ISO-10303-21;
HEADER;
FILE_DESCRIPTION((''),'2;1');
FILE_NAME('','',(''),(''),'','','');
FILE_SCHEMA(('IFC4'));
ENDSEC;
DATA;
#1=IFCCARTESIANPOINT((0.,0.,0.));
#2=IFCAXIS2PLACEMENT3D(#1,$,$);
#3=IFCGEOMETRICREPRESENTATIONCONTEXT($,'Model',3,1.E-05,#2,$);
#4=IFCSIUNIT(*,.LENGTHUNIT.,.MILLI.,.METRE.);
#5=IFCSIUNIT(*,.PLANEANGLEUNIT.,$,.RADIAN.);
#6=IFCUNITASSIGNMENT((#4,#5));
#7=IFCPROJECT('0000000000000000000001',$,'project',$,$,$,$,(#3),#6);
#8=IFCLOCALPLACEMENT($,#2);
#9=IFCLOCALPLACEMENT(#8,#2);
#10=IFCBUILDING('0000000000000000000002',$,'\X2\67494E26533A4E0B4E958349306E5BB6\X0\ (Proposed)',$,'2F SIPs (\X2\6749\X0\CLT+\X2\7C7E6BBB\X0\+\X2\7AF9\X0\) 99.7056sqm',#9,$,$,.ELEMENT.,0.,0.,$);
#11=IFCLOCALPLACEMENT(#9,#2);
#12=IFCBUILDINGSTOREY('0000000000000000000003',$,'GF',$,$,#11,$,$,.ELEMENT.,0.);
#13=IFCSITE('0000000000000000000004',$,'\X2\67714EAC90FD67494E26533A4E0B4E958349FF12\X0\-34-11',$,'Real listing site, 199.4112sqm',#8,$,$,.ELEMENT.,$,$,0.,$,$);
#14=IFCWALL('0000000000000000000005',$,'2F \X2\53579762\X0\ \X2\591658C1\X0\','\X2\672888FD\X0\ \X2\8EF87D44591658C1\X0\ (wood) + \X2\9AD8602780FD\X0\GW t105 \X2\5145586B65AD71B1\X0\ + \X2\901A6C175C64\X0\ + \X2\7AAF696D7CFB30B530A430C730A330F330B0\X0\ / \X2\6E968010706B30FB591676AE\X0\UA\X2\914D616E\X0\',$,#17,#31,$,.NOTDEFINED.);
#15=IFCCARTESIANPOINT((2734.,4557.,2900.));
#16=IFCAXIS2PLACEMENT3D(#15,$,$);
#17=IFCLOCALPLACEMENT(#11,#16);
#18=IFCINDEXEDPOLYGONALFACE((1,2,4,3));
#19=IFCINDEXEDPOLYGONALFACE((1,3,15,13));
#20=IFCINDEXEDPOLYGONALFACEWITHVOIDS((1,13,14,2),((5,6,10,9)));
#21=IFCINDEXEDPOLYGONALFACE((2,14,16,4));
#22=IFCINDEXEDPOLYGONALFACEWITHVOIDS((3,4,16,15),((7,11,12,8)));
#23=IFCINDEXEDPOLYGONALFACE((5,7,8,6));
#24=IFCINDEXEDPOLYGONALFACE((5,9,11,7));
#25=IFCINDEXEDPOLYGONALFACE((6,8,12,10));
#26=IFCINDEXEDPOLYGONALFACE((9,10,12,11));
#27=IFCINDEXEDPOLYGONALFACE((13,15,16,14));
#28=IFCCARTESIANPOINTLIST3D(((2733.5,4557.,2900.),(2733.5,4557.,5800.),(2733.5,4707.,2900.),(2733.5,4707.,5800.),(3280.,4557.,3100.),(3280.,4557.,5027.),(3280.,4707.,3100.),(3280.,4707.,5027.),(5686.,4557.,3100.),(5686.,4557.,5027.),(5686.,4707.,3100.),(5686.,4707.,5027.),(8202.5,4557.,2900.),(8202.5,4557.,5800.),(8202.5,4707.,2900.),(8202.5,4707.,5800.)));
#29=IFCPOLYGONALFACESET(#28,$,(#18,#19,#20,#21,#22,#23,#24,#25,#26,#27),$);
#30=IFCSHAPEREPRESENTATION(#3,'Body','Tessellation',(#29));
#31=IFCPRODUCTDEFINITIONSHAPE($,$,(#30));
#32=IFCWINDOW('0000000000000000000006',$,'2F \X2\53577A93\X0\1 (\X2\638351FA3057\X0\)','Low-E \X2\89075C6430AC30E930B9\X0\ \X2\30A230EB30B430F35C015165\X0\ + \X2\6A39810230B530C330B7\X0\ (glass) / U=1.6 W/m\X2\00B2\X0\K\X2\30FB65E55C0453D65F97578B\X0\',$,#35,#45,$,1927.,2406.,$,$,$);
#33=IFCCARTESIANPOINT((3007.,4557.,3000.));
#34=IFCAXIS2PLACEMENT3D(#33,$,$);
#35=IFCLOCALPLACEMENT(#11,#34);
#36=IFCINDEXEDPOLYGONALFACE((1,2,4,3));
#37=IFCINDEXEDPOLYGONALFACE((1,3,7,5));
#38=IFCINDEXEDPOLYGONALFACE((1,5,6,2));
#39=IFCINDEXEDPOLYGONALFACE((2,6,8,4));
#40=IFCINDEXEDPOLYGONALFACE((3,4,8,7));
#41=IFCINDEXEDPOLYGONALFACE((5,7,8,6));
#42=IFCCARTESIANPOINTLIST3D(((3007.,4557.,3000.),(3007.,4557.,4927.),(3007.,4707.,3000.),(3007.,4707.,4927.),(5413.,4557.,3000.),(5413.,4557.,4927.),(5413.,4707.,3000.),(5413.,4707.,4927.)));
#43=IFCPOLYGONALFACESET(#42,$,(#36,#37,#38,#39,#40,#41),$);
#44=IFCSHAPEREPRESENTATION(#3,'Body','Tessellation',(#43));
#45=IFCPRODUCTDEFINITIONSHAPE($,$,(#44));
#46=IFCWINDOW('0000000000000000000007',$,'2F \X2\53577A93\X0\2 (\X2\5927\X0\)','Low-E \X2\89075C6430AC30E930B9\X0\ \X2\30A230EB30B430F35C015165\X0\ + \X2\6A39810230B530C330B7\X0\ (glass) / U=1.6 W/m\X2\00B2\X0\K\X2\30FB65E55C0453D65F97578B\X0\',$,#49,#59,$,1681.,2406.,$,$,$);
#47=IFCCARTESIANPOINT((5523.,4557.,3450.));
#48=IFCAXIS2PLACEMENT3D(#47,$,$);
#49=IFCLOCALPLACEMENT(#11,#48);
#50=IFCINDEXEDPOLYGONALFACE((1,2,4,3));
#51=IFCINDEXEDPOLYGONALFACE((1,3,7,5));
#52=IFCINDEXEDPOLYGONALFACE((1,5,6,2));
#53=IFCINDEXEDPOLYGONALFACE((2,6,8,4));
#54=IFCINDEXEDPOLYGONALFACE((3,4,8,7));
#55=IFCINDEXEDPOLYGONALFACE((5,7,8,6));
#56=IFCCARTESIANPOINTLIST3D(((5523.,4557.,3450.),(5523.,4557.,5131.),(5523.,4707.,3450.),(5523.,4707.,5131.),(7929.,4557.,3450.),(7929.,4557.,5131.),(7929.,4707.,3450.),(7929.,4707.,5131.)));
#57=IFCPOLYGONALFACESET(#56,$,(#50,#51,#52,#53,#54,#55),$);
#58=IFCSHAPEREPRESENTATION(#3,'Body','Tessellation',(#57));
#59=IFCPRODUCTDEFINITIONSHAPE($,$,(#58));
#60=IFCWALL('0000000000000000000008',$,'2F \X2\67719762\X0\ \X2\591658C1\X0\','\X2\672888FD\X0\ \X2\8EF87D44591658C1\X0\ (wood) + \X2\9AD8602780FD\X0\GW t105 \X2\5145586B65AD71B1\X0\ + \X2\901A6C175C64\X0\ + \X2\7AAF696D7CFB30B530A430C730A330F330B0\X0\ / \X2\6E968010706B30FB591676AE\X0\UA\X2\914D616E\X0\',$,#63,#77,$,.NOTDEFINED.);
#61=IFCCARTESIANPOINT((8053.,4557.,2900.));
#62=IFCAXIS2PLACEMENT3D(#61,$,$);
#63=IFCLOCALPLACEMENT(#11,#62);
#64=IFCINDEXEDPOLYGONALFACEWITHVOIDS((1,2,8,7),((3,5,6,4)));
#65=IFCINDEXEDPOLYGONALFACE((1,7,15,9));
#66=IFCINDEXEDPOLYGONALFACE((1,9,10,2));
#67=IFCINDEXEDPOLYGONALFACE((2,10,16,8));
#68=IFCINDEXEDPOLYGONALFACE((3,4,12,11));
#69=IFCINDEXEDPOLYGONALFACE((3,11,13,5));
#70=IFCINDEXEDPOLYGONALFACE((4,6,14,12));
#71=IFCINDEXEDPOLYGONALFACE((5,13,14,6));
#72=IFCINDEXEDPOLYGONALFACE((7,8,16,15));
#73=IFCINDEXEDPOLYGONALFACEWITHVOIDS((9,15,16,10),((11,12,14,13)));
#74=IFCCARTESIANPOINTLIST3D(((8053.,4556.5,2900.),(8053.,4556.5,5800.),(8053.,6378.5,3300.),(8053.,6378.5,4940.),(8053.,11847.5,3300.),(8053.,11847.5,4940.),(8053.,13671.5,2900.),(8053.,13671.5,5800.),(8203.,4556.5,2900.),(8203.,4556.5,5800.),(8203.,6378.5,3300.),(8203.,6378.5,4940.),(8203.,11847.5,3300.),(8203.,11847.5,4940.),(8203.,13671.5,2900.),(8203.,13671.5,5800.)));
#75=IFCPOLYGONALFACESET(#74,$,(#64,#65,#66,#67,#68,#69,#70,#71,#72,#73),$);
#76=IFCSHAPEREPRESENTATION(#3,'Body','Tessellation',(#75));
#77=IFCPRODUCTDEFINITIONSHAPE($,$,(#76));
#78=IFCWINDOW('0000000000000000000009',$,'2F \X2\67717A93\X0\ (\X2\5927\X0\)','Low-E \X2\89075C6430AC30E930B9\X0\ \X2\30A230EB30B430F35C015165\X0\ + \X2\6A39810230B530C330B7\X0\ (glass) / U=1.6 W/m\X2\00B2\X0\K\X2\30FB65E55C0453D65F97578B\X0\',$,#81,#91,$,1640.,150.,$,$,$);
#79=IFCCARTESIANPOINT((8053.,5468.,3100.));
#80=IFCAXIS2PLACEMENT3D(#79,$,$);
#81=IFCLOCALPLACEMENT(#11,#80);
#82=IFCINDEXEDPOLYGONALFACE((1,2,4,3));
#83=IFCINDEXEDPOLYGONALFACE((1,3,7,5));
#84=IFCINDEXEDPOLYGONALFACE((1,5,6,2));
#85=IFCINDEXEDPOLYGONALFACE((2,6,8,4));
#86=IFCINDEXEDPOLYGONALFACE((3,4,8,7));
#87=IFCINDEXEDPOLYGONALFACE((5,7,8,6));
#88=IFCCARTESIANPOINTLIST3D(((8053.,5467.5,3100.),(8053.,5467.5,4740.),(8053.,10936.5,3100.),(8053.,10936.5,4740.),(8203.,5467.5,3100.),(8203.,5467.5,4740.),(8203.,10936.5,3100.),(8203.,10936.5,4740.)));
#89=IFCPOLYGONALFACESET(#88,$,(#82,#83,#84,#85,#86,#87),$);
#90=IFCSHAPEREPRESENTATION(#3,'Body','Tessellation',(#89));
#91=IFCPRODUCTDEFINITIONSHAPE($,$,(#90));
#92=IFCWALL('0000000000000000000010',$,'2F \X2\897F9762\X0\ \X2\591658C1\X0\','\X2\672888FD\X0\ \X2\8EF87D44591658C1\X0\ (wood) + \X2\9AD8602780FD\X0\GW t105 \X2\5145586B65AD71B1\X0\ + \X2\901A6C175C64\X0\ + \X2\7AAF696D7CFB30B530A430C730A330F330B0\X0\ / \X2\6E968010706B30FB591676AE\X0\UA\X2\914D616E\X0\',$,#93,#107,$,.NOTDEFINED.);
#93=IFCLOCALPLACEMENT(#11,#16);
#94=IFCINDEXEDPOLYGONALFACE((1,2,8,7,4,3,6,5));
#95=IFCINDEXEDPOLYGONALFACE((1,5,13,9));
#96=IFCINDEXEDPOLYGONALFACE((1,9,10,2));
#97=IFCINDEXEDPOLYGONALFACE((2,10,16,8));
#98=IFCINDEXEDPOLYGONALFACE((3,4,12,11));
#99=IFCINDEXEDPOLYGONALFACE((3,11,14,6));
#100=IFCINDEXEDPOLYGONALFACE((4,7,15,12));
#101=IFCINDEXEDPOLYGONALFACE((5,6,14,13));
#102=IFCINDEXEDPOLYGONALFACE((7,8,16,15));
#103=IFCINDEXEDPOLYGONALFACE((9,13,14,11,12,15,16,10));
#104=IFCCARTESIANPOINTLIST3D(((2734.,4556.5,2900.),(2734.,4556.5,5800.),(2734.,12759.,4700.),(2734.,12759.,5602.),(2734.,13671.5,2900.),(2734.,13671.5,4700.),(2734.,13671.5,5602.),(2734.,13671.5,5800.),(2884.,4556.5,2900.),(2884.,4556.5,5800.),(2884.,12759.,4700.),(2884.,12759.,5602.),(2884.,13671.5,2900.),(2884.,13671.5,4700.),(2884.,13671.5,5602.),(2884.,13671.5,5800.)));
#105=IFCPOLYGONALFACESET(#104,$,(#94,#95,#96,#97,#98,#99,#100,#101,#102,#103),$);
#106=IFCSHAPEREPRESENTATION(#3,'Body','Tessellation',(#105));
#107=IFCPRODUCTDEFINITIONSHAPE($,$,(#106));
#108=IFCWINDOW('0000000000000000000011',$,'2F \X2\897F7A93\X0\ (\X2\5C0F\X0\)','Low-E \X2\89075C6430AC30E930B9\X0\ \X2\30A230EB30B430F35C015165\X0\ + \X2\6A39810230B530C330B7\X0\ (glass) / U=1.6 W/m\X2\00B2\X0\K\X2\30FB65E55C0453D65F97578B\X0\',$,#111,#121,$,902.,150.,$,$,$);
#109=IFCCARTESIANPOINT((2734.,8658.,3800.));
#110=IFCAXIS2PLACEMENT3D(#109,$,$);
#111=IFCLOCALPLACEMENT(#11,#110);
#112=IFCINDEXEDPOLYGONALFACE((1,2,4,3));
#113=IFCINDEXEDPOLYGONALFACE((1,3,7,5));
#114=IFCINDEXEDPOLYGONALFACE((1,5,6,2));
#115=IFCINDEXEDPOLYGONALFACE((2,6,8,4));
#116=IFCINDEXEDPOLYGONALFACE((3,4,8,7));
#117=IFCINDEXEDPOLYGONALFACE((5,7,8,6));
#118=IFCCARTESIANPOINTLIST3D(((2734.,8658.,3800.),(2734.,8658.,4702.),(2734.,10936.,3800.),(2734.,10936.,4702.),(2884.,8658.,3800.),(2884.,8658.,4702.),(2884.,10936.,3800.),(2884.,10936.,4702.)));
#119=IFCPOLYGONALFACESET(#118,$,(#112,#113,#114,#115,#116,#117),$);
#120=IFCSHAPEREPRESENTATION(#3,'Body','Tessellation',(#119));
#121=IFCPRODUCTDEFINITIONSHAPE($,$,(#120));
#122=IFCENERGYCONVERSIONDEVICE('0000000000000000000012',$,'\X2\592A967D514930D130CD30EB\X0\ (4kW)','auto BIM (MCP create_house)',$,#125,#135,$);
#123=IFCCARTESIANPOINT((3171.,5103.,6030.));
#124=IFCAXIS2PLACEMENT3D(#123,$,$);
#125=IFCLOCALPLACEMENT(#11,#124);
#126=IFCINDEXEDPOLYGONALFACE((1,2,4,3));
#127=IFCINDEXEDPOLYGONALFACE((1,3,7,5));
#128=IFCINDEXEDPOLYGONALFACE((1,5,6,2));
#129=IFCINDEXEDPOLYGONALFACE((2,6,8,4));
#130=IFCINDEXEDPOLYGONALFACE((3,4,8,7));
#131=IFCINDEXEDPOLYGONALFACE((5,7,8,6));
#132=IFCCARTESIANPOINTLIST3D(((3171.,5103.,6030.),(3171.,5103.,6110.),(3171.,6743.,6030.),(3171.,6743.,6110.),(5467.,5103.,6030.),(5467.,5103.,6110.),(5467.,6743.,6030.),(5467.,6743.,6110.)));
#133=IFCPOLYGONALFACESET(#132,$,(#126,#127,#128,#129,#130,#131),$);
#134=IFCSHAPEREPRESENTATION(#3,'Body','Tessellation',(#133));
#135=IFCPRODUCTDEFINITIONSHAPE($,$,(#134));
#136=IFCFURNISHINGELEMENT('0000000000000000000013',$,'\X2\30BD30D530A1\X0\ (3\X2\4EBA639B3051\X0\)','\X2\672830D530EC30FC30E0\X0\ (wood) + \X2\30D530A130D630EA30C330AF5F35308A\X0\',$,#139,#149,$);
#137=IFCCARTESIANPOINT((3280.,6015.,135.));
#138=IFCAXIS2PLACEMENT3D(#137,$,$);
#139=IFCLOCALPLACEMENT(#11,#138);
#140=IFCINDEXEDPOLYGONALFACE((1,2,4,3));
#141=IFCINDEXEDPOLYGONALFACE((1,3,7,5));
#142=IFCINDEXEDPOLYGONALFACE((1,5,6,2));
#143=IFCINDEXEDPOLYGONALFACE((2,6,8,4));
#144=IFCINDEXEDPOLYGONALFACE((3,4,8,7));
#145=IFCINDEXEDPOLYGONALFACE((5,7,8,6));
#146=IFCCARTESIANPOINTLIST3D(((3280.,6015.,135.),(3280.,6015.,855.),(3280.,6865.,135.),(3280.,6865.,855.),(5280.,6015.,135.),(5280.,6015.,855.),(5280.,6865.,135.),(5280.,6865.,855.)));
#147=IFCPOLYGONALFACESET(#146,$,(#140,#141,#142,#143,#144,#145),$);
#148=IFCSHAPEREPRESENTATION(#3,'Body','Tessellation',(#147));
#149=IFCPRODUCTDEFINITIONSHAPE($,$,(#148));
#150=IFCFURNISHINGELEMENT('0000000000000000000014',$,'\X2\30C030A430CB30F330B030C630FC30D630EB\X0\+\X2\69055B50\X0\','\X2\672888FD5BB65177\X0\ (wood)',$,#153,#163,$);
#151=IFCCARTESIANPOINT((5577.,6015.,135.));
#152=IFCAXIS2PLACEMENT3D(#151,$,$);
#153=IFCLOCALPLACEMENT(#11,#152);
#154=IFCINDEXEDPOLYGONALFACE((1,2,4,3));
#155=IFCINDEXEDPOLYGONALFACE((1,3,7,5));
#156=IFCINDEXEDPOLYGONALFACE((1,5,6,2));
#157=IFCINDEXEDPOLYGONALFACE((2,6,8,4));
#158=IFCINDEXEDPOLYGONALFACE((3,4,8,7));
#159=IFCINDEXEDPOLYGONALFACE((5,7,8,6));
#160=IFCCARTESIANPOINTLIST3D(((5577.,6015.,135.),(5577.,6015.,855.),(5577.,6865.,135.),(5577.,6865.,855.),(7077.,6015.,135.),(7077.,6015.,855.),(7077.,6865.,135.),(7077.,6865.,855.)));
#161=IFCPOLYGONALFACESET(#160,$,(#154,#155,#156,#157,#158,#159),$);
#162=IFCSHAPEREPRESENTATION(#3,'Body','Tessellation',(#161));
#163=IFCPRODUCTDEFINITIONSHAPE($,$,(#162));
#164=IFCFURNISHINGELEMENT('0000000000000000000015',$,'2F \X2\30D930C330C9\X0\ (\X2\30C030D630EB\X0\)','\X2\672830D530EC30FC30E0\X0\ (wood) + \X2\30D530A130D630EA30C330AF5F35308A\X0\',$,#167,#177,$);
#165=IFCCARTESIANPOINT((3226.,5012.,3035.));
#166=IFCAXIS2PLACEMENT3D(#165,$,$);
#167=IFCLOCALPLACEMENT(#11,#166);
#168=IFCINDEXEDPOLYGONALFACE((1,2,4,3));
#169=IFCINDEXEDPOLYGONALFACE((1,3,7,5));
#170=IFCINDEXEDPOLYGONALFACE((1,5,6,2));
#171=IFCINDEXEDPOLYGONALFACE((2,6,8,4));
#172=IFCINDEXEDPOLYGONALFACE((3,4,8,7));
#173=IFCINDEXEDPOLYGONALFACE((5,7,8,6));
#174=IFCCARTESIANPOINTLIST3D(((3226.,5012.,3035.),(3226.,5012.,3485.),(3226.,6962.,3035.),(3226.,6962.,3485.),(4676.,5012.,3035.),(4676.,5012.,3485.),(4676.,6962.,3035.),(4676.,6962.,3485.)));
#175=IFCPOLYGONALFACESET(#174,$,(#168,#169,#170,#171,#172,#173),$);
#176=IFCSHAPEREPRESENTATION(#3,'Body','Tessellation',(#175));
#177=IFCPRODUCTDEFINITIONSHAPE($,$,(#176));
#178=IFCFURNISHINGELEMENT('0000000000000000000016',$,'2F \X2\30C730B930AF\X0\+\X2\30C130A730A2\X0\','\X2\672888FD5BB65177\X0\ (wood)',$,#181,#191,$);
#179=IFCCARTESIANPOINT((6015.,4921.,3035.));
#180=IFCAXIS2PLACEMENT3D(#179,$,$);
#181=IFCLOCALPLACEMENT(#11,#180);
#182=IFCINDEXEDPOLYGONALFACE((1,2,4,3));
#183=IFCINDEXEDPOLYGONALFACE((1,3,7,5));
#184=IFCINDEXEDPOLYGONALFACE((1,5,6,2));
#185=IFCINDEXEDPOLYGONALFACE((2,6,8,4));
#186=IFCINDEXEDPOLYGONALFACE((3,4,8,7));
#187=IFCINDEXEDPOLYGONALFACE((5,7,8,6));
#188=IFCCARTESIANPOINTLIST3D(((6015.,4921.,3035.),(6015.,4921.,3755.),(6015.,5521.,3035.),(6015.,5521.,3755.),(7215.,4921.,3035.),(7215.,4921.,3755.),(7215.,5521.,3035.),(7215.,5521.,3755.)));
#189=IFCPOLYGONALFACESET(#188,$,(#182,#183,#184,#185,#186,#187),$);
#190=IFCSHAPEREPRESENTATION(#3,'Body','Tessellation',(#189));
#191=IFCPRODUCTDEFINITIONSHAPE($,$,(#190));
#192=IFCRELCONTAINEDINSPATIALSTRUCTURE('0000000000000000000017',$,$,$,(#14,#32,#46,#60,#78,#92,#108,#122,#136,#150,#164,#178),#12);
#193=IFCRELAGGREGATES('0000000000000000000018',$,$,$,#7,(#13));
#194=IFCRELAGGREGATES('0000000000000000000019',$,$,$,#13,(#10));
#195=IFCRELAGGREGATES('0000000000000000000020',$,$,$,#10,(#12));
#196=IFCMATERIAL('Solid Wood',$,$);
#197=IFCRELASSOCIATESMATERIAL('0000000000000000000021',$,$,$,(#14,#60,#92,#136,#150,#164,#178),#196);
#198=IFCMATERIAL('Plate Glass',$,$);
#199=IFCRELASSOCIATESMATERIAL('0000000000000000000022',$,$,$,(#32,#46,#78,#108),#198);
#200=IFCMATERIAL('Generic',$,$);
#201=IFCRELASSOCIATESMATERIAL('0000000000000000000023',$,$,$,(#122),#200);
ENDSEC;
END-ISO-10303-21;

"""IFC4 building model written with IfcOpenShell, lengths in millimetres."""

from ifc_helpers import new_model, si_unit, frame, frame_2d, origin, place, context, project, spatial, rectangle, extrude, material, element, fill, save


model = new_model("IFC4")

# Units and contexts
model_context = context("Model", 3, precision=1e-05, world=origin())
ifc_project = project(units=[si_unit("LENGTHUNIT", "METRE", prefix="MILLI"), si_unit("PLANEANGLEUNIT", "RADIAN")], contexts=[model_context])

# Site, building, storey
site_placement = place(None, origin())
site = spatial("IfcSite", under=ifc_project, at=site_placement, Name="東京都杉並区下井草２-34-11", ObjectType="Real listing site, 199.4112sqm", CompositionType="ELEMENT", RefElevation=0.0)
building_placement = place(site_placement, origin())
building = spatial("IfcBuilding", under=site, at=building_placement, Name="杉並区下井草の家 (Proposed)", ObjectType="2F SIPs (杉CLT+籾殻+竹) 99.7056sqm", CompositionType="ELEMENT", ElevationOfRefHeight=0.0, ElevationOfTerrain=0.0)
storey_placement = place(building_placement, origin())
storey = spatial("IfcBuildingStorey", under=building, at=storey_placement, Name="GF", CompositionType="ELEMENT", Elevation=0.0)

# Shared definitions
ifc_material_1 = material(Name="Solid Wood")

# Wall, openings, windows
wall_1_placement = place(storey_placement, frame((2734.0, 4557.0, 2900.0)))
wall_1 = element("IfcWall", 1, at=wall_1_placement, inside=storey, material=ifc_material_1, Name="2F 南面 外壁", Description="木製 軸組外壁 (wood) + 高性能GW t105 充填断熱 + 通気層 + 窯業系サイディング / 準耐火・外皮UA配慮", PredefinedType="NOTDEFINED", context=model_context, shape_type="SweptSolid", body=[
    extrude(rectangle(XDim=5469.0, YDim=150.0, at=frame_2d((2734.0, 75.0))), frame((2734.0, 4557.0, 2900.0)), (0.0, 0.0, 1.0), 2900.0),
])
opening_1_placement = place(storey_placement, frame((3007.0, 4557.0, 3000.0)))
opening_1 = element("IfcOpeningElement", 2, at=opening_1_placement, cuts=wall_1, PredefinedType="NOTDEFINED", context=model_context, shape_type="SweptSolid", body=[
    extrude(rectangle(XDim=2406.0, YDim=150.0, at=frame_2d((1203.0, 75.0))), frame((3007.0, 4557.0, 3000.0)), (0.0, 0.0, 1.0), 1927.0),
])
opening_2_placement = place(storey_placement, frame((5523.0, 4557.0, 3450.0)))
opening_2 = element("IfcOpeningElement", 3, at=opening_2_placement, cuts=wall_1, PredefinedType="NOTDEFINED", context=model_context, shape_type="SweptSolid", body=[
    extrude(rectangle(XDim=2406.0, YDim=150.0, at=frame_2d((1203.0, 75.0))), frame((5523.0, 4557.0, 3450.0)), (0.0, 0.0, 1.0), 1681.0),
])
ifc_material_2 = material(Name="Plate Glass")
window_1_placement = place(storey_placement, frame((3007.0, 4557.0, 3000.0)))
window_1 = element("IfcWindow", 4, at=window_1_placement, inside=storey, material=ifc_material_2, Name="2F 南窓1 (掃出し)", Description="Low-E 複層ガラス アルゴン封入 + 樹脂サッシ (glass) / U=1.6 W/m²K・日射取得型", OverallHeight=1927.0, OverallWidth=2406.0, context=model_context, shape_type="SweptSolid", body=[
    extrude(rectangle(XDim=2406.0, YDim=150.0, at=frame_2d((1203.0, 75.0))), frame((3007.0, 4557.0, 3000.0)), (0.0, 0.0, 1.0), 1927.0),
])
fill(opening_1, window_1)
window_2_placement = place(storey_placement, frame((5523.0, 4557.0, 3450.0)))
window_2 = element("IfcWindow", 5, at=window_2_placement, inside=storey, material=ifc_material_2, Name="2F 南窓2 (大)", Description="Low-E 複層ガラス アルゴン封入 + 樹脂サッシ (glass) / U=1.6 W/m²K・日射取得型", OverallHeight=1681.0, OverallWidth=2406.0, context=model_context, shape_type="SweptSolid", body=[
    extrude(rectangle(XDim=2406.0, YDim=150.0, at=frame_2d((1203.0, 75.0))), frame((5523.0, 4557.0, 3450.0)), (0.0, 0.0, 1.0), 1681.0),
])
fill(opening_2, window_2)

# Walls, openings, windows
wall_2_placement = place(storey_placement, frame((8053.0, 4557.0, 2900.0)))
wall_2 = element("IfcWall", 6, at=wall_2_placement, inside=storey, material=ifc_material_1, Name="2F 東面 外壁", Description="木製 軸組外壁 (wood) + 高性能GW t105 充填断熱 + 通気層 + 窯業系サイディング / 準耐火・外皮UA配慮", PredefinedType="NOTDEFINED", context=model_context, shape_type="SweptSolid", body=[
    extrude(rectangle(XDim=150.0, YDim=9115.0, at=frame_2d((75.0, 4557.0))), frame((8053.0, 4557.0, 2900.0)), (0.0, 0.0, 1.0), 2900.0),
])
opening_3_placement = place(storey_placement, frame((8053.0, 5468.0, 3100.0)))
opening_3 = element("IfcOpeningElement", 7, at=opening_3_placement, cuts=wall_2, PredefinedType="NOTDEFINED", context=model_context, shape_type="SweptSolid", body=[
    extrude(rectangle(XDim=150.0, YDim=5469.0, at=frame_2d((75.0, 2734.0))), frame((8053.0, 5468.0, 3100.0)), (0.0, 0.0, 1.0), 1640.0),
])
window_3_placement = place(storey_placement, frame((8053.0, 5468.0, 3100.0)))
window_3 = element("IfcWindow", 8, at=window_3_placement, inside=storey, material=ifc_material_2, Name="2F 東窓 (大)", Description="Low-E 複層ガラス アルゴン封入 + 樹脂サッシ (glass) / U=1.6 W/m²K・日射取得型", OverallHeight=1640.0, OverallWidth=150.0, context=model_context, shape_type="SweptSolid", body=[
    extrude(rectangle(XDim=150.0, YDim=5469.0, at=frame_2d((75.0, 2734.0))), frame((8053.0, 5468.0, 3100.0)), (0.0, 0.0, 1.0), 1640.0),
])
fill(opening_3, window_3)
wall_3_placement = place(storey_placement, frame((2734.0, 4557.0, 2900.0)))
wall_3 = element("IfcWall", 9, at=wall_3_placement, inside=storey, material=ifc_material_1, Name="2F 西面 外壁", Description="木製 軸組外壁 (wood) + 高性能GW t105 充填断熱 + 通気層 + 窯業系サイディング / 準耐火・外皮UA配慮", PredefinedType="NOTDEFINED", context=model_context, shape_type="SweptSolid", body=[
    extrude(rectangle(XDim=150.0, YDim=9115.0, at=frame_2d((75.0, 4557.0))), frame((2734.0, 4557.0, 2900.0)), (0.0, 0.0, 1.0), 2900.0),
])
opening_4_placement = place(storey_placement, frame((2734.0, 8658.0, 3800.0)))
opening_4 = element("IfcOpeningElement", 10, at=opening_4_placement, cuts=wall_3, PredefinedType="NOTDEFINED", context=model_context, shape_type="SweptSolid", body=[
    extrude(rectangle(XDim=150.0, YDim=2278.0, at=frame_2d((75.0, 1139.0))), frame((2734.0, 8658.0, 3800.0)), (0.0, 0.0, 1.0), 902.0),
])
window_4_placement = place(storey_placement, frame((2734.0, 8658.0, 3800.0)))
window_4 = element("IfcWindow", 11, at=window_4_placement, inside=storey, material=ifc_material_2, Name="2F 西窓 (小)", Description="Low-E 複層ガラス アルゴン封入 + 樹脂サッシ (glass) / U=1.6 W/m²K・日射取得型", OverallHeight=902.0, OverallWidth=150.0, context=model_context, shape_type="SweptSolid", body=[
    extrude(rectangle(XDim=150.0, YDim=2278.0, at=frame_2d((75.0, 1139.0))), frame((2734.0, 8658.0, 3800.0)), (0.0, 0.0, 1.0), 902.0),
])
fill(opening_4, window_4)

# Shared definitions
ifc_material_3 = material(Name="Generic")

# Energy conversion device
energy_conversion_device_placement = place(storey_placement, frame((3171.0, 5103.0, 6030.0)))
element("IfcEnergyConversionDevice", 12, at=energy_conversion_device_placement, inside=storey, material=ifc_material_3, Name="太陽光パネル (4kW)", Description="auto BIM (MCP create_house)", context=model_context, shape_type="SweptSolid", body=[
    extrude(rectangle(XDim=2296.0, YDim=1640.0, at=frame_2d((1148.0, 820.0))), frame((3171.0, 5103.0, 6030.0)), (0.0, 0.0, 1.0), 80.0),
])

# Furnishing elements
furnishing_1_placement = place(storey_placement, frame((3280.0, 6015.0, 135.0)))
element("IfcFurnishingElement", 13, at=furnishing_1_placement, inside=storey, material=ifc_material_1, Name="ソファ (3人掛け)", Description="木フレーム (wood) + ファブリック張り", context=model_context, shape_type="SweptSolid", body=[
    extrude(rectangle(XDim=2000.0, YDim=850.0, at=frame_2d((1000.0, 425.0))), frame((3280.0, 6015.0, 135.0)), (0.0, 0.0, 1.0), 720.0),
])
furnishing_2_placement = place(storey_placement, frame((5577.0, 6015.0, 135.0)))
element("IfcFurnishingElement", 14, at=furnishing_2_placement, inside=storey, material=ifc_material_1, Name="ダイニングテーブル+椅子", Description="木製家具 (wood)", context=model_context, shape_type="SweptSolid", body=[
    extrude(rectangle(XDim=1500.0, YDim=850.0, at=frame_2d((750.0, 425.0))), frame((5577.0, 6015.0, 135.0)), (0.0, 0.0, 1.0), 720.0),
])
furnishing_3_placement = place(storey_placement, frame((3226.0, 5012.0, 3035.0)))
element("IfcFurnishingElement", 15, at=furnishing_3_placement, inside=storey, material=ifc_material_1, Name="2F ベッド (ダブル)", Description="木フレーム (wood) + ファブリック張り", context=model_context, shape_type="SweptSolid", body=[
    extrude(rectangle(XDim=1450.0, YDim=1950.0, at=frame_2d((725.0, 975.0))), frame((3226.0, 5012.0, 3035.0)), (0.0, 0.0, 1.0), 450.0),
])
furnishing_4_placement = place(storey_placement, frame((6015.0, 4921.0, 3035.0)))
element("IfcFurnishingElement", 16, at=furnishing_4_placement, inside=storey, material=ifc_material_1, Name="2F デスク+チェア", Description="木製家具 (wood)", context=model_context, shape_type="SweptSolid", body=[
    extrude(rectangle(XDim=1200.0, YDim=600.0, at=frame_2d((600.0, 300.0))), frame((6015.0, 4921.0, 3035.0)), (0.0, 0.0, 1.0), 720.0),
])

save(model, "model.ifc")
